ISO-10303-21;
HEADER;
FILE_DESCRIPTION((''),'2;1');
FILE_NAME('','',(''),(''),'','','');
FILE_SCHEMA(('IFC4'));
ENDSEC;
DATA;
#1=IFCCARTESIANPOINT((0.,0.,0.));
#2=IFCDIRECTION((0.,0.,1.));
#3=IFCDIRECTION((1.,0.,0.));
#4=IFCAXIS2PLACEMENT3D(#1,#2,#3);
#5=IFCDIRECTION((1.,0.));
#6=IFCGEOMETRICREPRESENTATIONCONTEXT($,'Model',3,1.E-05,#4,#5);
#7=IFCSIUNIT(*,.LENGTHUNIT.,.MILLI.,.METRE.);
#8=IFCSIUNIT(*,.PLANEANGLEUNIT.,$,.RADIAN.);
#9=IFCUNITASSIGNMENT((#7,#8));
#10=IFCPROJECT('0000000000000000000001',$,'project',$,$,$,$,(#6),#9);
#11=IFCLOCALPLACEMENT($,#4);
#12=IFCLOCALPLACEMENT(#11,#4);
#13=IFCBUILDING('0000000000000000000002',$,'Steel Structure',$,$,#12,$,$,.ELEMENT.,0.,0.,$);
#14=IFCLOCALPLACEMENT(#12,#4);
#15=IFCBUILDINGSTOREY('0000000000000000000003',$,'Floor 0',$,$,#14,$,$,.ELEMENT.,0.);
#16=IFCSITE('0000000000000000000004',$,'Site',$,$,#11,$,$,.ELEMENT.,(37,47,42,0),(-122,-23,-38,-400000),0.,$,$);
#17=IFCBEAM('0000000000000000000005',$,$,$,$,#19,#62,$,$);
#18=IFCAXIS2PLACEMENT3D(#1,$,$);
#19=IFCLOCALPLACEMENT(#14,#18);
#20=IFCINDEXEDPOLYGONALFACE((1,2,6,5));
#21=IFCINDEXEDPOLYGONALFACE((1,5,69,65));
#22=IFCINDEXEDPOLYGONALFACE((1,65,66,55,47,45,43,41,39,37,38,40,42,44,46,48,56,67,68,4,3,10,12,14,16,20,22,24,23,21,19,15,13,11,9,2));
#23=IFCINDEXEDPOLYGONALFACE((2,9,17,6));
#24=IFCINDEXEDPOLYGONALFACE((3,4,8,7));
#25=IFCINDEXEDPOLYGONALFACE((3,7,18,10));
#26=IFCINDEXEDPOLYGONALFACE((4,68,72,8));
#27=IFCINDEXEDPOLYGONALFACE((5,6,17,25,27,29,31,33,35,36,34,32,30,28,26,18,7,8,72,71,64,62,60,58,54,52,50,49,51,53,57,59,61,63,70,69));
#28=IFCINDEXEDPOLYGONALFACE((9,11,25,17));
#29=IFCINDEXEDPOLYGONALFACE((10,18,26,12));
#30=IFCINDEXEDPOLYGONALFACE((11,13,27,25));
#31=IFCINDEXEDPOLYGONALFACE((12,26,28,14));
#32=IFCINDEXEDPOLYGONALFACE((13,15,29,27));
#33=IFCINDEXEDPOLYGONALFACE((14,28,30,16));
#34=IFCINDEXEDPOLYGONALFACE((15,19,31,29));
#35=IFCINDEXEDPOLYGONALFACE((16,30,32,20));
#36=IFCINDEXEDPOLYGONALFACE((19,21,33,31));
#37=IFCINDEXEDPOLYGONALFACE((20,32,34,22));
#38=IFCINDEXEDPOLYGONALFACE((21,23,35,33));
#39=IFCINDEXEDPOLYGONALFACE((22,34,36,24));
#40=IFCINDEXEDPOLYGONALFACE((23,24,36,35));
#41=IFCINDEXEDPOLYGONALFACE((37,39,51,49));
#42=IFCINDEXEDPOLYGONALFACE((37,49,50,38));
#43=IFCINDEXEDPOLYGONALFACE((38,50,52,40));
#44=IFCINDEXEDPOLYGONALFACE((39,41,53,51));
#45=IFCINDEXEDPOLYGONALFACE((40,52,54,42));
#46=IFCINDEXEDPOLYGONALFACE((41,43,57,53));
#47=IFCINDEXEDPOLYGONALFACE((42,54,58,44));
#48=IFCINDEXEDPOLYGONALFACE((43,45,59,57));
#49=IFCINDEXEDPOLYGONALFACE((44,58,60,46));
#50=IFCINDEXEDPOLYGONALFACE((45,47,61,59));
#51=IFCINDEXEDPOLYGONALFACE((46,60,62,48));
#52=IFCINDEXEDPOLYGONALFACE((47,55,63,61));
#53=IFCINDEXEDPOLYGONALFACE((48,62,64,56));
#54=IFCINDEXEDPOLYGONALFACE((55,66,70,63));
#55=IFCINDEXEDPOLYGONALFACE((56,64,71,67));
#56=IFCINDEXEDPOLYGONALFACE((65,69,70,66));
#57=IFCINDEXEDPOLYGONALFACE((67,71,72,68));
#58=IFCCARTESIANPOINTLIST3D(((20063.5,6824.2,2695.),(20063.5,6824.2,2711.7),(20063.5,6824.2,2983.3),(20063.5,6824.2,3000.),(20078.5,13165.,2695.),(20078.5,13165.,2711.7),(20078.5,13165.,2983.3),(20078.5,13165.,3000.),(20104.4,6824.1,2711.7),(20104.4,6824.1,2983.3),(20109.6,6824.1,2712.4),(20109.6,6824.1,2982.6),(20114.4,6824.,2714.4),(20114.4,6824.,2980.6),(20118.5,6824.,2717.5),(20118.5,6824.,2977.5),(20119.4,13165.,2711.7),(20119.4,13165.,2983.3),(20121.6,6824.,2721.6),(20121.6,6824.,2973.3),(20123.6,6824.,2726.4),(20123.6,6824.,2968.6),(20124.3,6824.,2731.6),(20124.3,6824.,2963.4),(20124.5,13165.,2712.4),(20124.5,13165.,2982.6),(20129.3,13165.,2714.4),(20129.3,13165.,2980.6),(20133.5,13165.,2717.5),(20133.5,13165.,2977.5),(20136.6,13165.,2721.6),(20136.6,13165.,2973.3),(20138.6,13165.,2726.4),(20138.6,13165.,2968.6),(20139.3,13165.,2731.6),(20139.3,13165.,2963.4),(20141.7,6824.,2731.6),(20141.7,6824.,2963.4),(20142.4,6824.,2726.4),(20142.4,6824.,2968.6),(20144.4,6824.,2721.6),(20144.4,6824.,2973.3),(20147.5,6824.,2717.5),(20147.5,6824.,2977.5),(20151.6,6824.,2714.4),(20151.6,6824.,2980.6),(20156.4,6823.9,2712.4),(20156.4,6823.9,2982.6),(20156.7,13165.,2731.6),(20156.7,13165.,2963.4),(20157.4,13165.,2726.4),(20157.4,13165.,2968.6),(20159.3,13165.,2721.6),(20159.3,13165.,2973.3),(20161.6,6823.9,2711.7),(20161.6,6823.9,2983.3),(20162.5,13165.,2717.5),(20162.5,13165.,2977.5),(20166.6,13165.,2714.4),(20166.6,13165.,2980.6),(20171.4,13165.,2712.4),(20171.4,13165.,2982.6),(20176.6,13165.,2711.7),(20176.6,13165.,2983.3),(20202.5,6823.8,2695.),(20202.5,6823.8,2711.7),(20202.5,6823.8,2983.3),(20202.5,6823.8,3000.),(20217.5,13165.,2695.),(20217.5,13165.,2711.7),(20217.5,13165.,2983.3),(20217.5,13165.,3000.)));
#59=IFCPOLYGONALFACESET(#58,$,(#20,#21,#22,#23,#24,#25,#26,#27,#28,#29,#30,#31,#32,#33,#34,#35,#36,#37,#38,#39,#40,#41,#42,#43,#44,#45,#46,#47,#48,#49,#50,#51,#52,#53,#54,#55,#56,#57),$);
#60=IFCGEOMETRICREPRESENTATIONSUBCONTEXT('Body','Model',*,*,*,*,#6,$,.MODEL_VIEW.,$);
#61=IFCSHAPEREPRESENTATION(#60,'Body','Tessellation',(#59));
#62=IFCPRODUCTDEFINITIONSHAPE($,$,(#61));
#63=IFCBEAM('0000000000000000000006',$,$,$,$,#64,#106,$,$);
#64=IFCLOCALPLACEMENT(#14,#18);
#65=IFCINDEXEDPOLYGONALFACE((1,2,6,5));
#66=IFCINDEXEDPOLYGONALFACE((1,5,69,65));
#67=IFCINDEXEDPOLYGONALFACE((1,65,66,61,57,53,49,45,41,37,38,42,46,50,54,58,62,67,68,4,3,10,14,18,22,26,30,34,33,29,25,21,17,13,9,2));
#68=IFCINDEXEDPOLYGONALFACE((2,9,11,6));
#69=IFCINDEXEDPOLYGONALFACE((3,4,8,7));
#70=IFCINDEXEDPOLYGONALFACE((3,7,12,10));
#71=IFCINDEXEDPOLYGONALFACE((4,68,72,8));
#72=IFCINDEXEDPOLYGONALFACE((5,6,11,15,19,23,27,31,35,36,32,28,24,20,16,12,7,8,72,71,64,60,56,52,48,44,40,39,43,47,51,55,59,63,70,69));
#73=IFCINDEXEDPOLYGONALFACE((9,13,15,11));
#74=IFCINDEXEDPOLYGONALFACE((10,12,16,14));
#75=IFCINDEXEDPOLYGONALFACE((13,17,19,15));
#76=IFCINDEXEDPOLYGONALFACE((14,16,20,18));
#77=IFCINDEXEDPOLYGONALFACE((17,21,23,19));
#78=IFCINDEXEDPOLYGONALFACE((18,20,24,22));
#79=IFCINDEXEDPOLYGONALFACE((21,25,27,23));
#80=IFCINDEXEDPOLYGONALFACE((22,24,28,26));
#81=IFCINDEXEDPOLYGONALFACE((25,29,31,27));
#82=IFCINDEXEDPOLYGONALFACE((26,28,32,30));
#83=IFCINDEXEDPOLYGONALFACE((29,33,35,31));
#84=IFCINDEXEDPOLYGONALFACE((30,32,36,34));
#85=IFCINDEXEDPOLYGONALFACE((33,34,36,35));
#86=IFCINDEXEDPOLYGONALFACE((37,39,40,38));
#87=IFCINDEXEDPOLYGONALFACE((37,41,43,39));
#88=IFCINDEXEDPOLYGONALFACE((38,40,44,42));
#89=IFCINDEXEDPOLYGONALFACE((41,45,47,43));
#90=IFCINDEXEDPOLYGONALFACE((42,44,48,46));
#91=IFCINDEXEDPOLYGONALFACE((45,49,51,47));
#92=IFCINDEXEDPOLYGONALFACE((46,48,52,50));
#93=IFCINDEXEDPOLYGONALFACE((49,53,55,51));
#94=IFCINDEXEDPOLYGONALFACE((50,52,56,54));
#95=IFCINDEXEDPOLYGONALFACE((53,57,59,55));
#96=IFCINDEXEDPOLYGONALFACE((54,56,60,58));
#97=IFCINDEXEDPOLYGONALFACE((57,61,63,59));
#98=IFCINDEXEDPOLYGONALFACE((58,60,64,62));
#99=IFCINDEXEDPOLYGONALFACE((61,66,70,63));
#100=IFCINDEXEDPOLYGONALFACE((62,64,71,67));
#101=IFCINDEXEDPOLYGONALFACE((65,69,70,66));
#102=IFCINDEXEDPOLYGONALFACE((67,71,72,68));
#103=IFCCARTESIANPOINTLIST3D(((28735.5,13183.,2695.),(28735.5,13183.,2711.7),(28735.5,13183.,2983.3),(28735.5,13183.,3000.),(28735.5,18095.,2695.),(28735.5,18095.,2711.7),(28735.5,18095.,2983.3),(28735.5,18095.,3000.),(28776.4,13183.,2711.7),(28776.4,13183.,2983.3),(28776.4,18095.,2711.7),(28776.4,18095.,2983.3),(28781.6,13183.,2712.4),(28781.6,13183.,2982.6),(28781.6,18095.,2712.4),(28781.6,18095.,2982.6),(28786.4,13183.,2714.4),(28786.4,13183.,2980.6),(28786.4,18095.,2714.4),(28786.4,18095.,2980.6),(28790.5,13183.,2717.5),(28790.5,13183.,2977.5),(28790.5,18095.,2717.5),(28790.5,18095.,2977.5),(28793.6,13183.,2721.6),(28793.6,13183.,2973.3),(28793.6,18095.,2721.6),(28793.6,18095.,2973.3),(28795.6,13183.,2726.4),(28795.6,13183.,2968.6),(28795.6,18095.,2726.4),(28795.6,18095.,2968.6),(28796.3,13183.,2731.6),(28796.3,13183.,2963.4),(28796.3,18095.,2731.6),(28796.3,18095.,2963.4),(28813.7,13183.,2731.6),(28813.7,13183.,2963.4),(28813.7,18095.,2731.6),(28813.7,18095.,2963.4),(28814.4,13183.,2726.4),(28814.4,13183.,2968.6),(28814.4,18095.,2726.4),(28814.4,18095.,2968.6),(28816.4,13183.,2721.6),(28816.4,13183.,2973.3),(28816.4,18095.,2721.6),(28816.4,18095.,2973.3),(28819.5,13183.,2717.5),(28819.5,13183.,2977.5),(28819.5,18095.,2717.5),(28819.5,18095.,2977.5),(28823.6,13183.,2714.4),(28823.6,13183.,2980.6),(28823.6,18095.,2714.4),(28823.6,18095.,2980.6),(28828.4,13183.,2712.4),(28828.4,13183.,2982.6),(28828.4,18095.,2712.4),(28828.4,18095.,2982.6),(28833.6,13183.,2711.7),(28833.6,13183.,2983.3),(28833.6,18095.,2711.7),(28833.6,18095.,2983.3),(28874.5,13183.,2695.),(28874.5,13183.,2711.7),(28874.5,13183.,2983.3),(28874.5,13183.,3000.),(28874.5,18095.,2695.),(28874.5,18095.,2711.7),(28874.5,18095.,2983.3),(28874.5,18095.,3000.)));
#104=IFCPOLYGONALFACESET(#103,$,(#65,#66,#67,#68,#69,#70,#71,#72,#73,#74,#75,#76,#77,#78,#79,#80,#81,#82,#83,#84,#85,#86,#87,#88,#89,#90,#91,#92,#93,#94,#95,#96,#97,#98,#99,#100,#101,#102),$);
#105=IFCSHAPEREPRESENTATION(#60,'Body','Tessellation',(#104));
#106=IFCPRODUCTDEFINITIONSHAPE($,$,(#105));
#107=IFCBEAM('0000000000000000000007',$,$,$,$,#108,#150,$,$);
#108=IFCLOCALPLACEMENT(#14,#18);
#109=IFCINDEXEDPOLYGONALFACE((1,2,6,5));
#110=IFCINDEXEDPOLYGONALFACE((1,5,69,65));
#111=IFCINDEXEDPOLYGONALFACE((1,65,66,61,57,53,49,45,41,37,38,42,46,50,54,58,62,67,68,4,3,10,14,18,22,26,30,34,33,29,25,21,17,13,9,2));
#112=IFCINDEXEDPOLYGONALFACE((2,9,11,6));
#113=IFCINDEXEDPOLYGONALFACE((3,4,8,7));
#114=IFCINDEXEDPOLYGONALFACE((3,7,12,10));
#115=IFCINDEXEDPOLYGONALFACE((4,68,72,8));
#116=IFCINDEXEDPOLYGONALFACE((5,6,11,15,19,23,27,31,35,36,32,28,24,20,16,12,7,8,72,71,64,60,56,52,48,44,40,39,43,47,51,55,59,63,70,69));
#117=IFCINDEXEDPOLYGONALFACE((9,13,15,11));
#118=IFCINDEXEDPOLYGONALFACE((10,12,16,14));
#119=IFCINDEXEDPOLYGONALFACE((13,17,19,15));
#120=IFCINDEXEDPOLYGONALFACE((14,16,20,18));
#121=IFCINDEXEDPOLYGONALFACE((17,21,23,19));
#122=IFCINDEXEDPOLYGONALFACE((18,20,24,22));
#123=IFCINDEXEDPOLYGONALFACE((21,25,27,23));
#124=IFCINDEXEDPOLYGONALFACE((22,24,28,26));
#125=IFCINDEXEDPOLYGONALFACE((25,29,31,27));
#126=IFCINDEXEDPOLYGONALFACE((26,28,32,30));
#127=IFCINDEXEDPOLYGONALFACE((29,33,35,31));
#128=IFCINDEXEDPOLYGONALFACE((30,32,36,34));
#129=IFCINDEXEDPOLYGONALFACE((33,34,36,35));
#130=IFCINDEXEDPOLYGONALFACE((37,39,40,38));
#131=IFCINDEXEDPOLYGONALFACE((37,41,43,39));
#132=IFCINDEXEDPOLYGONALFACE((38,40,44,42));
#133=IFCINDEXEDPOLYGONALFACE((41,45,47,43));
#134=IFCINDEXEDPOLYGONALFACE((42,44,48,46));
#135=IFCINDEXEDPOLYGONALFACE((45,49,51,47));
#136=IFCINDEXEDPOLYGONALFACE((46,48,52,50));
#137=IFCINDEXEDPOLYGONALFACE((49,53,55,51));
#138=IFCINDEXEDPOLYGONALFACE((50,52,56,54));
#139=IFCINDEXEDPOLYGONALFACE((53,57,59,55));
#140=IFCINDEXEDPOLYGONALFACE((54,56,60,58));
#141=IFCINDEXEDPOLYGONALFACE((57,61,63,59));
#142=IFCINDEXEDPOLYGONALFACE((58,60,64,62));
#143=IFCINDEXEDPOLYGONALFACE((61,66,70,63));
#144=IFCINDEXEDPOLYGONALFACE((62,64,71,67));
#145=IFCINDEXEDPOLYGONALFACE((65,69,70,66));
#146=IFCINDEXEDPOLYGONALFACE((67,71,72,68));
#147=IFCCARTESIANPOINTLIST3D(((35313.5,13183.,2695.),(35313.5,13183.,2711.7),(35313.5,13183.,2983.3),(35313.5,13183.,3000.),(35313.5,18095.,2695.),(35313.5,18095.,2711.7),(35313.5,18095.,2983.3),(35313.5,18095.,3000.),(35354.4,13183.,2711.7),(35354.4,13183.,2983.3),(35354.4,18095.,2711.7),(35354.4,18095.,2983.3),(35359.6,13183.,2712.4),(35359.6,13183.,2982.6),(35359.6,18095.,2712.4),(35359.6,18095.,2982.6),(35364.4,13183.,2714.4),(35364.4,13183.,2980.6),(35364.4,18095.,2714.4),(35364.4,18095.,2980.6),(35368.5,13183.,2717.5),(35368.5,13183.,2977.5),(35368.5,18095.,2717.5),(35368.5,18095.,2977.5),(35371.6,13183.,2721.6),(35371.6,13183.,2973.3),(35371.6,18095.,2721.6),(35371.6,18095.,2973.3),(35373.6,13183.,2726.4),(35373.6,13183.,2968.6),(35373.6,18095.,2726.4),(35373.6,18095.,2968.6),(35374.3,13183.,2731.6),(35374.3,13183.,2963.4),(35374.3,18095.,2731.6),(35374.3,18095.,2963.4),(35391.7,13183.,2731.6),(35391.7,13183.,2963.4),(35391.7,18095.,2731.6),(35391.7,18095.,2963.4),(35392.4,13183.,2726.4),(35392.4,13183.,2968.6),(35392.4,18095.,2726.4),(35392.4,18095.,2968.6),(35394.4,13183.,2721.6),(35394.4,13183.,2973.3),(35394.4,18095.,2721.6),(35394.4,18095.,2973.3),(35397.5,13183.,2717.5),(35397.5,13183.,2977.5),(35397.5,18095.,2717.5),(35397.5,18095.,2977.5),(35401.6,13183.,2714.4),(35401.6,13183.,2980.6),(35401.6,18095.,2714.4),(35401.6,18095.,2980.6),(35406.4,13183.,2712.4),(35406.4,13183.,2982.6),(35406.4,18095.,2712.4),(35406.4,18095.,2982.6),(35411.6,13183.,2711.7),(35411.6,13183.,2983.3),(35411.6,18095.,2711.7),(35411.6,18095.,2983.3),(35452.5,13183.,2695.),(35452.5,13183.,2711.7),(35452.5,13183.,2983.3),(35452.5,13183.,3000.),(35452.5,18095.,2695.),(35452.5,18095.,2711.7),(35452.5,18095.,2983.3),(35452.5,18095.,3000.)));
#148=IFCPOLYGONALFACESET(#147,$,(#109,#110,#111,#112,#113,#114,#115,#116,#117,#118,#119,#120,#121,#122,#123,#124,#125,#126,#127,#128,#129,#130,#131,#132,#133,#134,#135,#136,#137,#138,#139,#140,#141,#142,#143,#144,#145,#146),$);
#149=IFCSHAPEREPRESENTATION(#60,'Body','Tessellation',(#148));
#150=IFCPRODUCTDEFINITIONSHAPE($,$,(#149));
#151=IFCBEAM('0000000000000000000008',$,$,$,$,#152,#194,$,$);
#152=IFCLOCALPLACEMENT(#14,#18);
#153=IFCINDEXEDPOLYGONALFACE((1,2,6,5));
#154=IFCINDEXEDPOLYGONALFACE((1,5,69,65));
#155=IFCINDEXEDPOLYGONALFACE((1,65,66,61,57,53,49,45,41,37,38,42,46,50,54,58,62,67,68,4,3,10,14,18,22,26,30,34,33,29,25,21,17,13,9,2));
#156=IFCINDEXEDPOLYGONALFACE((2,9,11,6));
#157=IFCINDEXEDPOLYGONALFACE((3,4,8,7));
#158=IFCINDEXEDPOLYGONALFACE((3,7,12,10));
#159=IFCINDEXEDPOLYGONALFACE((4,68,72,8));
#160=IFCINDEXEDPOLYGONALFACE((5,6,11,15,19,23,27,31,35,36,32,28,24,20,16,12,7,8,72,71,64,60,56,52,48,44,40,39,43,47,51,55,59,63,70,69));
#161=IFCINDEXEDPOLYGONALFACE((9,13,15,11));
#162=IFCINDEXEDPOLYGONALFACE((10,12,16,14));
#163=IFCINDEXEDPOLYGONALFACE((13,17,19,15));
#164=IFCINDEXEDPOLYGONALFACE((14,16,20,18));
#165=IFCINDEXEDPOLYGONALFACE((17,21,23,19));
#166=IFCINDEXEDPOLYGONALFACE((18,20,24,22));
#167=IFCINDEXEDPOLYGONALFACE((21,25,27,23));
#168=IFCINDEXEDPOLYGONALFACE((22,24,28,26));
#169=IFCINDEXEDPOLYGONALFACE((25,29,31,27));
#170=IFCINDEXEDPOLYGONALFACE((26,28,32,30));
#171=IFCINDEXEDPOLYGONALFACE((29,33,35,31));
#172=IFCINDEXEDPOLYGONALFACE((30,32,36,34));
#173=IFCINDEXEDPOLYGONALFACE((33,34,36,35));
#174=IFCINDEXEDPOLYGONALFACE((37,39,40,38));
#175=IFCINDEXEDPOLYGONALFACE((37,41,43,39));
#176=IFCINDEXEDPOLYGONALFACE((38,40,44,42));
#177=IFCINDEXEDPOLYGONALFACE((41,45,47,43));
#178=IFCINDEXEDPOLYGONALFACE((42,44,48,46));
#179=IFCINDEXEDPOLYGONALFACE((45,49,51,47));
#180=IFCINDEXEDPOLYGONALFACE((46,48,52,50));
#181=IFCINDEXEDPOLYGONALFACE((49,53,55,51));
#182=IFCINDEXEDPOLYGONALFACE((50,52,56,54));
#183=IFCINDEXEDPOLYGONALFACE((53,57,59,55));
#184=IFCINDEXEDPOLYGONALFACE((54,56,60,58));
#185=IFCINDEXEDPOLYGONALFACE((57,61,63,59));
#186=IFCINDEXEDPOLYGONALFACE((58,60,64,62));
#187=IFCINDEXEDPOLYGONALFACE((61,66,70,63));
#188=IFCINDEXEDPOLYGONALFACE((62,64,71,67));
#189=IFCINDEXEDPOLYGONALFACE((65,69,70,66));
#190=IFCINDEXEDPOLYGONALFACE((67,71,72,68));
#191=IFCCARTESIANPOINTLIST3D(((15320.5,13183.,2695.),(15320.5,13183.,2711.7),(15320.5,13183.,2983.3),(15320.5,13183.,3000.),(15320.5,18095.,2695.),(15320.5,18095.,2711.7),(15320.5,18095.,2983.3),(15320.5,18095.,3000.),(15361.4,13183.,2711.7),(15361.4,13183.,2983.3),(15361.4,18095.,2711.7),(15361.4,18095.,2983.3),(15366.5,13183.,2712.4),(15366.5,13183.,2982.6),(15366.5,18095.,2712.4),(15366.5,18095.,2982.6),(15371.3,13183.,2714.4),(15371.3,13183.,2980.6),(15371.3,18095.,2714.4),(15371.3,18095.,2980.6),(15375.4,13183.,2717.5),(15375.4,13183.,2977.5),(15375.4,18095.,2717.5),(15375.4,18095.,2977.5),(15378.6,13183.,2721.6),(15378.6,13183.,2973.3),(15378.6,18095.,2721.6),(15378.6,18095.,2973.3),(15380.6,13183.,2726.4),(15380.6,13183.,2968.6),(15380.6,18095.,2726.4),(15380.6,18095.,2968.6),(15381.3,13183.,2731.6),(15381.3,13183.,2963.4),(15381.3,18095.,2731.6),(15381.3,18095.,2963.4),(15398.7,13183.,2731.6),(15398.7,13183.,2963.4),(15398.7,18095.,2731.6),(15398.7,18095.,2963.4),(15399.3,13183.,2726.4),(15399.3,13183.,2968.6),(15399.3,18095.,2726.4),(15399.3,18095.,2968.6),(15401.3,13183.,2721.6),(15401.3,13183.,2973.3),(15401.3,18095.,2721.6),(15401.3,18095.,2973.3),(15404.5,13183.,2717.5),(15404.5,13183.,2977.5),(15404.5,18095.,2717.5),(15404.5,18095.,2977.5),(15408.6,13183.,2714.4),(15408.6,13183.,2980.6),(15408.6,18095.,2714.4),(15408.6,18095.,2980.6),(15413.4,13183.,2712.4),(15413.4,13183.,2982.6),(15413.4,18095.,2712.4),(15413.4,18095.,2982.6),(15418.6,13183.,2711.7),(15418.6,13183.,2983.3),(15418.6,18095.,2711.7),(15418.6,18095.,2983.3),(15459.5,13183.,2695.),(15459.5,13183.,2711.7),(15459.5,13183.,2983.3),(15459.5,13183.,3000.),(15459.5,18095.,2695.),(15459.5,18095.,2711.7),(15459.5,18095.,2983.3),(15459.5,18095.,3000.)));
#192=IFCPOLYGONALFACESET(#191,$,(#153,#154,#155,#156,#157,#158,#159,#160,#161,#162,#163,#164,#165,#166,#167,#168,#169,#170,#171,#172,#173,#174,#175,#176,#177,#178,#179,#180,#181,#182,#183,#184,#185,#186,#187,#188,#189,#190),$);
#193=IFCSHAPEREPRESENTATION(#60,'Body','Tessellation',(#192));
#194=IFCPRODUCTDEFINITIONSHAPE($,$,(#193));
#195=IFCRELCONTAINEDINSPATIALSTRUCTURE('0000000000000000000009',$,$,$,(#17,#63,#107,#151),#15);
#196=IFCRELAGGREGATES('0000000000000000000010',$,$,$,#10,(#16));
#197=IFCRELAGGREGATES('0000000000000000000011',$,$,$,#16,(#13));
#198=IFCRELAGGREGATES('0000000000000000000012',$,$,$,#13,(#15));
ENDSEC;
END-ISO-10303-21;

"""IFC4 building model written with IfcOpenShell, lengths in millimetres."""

from ifc_helpers import new_model, si_unit, direction, frame, origin_with_axes, origin_2d_with_axis, place, context, subcontext, project, spatial, polyline, i_section, extrude, clip, bounded_halfspace, element, save


model = new_model("IFC4")

# Units and contexts
model_context = context("Model", 3, precision=1e-05, world=origin_with_axes(), true_north=direction((1.0, 0.0)))
body_context = subcontext(model_context, "Body", "Model", "MODEL_VIEW")
ifc_project = project(units=[si_unit("LENGTHUNIT", "METRE", prefix="MILLI"), si_unit("PLANEANGLEUNIT", "RADIAN")], contexts=[model_context])

# Site, building, storey
site_placement = place(None, origin_with_axes())
site = spatial("IfcSite", under=ifc_project, at=site_placement, Name="Site", CompositionType="ELEMENT", RefLatitude=(37, 47, 42, 0), RefLongitude=(-122, -23, -38, -400000), RefElevation=0.0)
building_placement = place(site_placement, origin_with_axes())
building = spatial("IfcBuilding", under=site, at=building_placement, Name="Steel Structure", CompositionType="ELEMENT", ElevationOfRefHeight=0.0, ElevationOfTerrain=0.0)
storey_placement = place(building_placement, origin_with_axes())
storey = spatial("IfcBuildingStorey", under=building, at=storey_placement, Name="Floor 0", CompositionType="ELEMENT", Elevation=0.0)

# Beams
beam_1_placement = place(storey_placement, frame((20148.0, 13165.2, 2695.0), z_axis=(-0.002362, -0.999997, 0.0), x_axis=(0.999997, -0.002362, 0.0)))
element("IfcBeam", 1, at=beam_1_placement, inside=storey, context=body_context, shape_type="Clipping", body=[
    clip(extrude(i_section(OverallWidth=139.0, OverallDepth=305.0, WebThickness=17.4, FlangeThickness=16.7, FilletRadius=19.9, at=origin_2d_with_axis()), frame((0.0, 152.5, 0.0), z_axis=(0.0, 0.0, 1.0), x_axis=(1.0, 0.0, 0.0)), (0.0, 0.0, 1.0), 6341.2), bounded_halfspace(frame((-20147.9, -2695.0, 47.8), z_axis=(-0.002362, 0.0, -0.999997), x_axis=(-0.999997, 0.0, 0.002362)), False, frame((0.0, 152.5, 0.0), z_axis=(0.0, 0.0, 1.0), x_axis=(1.0, 0.0, 0.0)), polyline([(69.5, 152.5), (69.5, 135.8), (28.6, 135.8), (8.7, 115.9), (8.7, -115.9), (28.6, -135.8), (69.5, -135.8), (69.5, -152.5), (-69.5, -152.5), (-69.5, -135.8), (-28.6, -135.8), (-8.7, -115.9), (-8.7, 115.9), (-28.6, 135.8), (-69.5, 135.8), (-69.5, 152.5), (69.5, 152.5)]))),
])
beam_2_placement = place(storey_placement, frame((28805.0, 13183.0, 2695.0), z_axis=(0.0, 1.0, 0.0), x_axis=(-1.0, 0.0, 0.0)))
element("IfcBeam", 2, at=beam_2_placement, inside=storey, context=body_context, shape_type="SweptSolid", body=[
    extrude(i_section(OverallWidth=139.0, OverallDepth=305.0, WebThickness=17.4, FlangeThickness=16.7, FilletRadius=19.9, at=origin_2d_with_axis()), frame((0.0, 152.5, 0.0), z_axis=(0.0, 0.0, 1.0), x_axis=(1.0, 0.0, 0.0)), (0.0, 0.0, 1.0), 4912.0),
])
for number, where, z_axis, x_axis in (
    (3, (35383.0, 13183.0, 2695.0), (0.0, 1.0, 0.0), (-1.0, 0.0, 0.0)),
    (4, (15390.0, 13183.0, 2695.0), (0.0, 1.0, 0.0), (-1.0, 0.0, 0.0)),
):
    element("IfcBeam", number, at=place(storey_placement, frame(where, z_axis=z_axis, x_axis=x_axis)), inside=storey, context=body_context, shape_type="SweptSolid", body=[
        extrude(i_section(OverallWidth=139.0, OverallDepth=305.0, WebThickness=17.4, FlangeThickness=16.7, FilletRadius=19.9, at=origin_2d_with_axis()), frame((0.0, 152.5, 0.0), z_axis=(0.0, 0.0, 1.0), x_axis=(1.0, 0.0, 0.0)), (0.0, 0.0, 1.0), 4912.0),
    ])

save(model, "model.ifc")
